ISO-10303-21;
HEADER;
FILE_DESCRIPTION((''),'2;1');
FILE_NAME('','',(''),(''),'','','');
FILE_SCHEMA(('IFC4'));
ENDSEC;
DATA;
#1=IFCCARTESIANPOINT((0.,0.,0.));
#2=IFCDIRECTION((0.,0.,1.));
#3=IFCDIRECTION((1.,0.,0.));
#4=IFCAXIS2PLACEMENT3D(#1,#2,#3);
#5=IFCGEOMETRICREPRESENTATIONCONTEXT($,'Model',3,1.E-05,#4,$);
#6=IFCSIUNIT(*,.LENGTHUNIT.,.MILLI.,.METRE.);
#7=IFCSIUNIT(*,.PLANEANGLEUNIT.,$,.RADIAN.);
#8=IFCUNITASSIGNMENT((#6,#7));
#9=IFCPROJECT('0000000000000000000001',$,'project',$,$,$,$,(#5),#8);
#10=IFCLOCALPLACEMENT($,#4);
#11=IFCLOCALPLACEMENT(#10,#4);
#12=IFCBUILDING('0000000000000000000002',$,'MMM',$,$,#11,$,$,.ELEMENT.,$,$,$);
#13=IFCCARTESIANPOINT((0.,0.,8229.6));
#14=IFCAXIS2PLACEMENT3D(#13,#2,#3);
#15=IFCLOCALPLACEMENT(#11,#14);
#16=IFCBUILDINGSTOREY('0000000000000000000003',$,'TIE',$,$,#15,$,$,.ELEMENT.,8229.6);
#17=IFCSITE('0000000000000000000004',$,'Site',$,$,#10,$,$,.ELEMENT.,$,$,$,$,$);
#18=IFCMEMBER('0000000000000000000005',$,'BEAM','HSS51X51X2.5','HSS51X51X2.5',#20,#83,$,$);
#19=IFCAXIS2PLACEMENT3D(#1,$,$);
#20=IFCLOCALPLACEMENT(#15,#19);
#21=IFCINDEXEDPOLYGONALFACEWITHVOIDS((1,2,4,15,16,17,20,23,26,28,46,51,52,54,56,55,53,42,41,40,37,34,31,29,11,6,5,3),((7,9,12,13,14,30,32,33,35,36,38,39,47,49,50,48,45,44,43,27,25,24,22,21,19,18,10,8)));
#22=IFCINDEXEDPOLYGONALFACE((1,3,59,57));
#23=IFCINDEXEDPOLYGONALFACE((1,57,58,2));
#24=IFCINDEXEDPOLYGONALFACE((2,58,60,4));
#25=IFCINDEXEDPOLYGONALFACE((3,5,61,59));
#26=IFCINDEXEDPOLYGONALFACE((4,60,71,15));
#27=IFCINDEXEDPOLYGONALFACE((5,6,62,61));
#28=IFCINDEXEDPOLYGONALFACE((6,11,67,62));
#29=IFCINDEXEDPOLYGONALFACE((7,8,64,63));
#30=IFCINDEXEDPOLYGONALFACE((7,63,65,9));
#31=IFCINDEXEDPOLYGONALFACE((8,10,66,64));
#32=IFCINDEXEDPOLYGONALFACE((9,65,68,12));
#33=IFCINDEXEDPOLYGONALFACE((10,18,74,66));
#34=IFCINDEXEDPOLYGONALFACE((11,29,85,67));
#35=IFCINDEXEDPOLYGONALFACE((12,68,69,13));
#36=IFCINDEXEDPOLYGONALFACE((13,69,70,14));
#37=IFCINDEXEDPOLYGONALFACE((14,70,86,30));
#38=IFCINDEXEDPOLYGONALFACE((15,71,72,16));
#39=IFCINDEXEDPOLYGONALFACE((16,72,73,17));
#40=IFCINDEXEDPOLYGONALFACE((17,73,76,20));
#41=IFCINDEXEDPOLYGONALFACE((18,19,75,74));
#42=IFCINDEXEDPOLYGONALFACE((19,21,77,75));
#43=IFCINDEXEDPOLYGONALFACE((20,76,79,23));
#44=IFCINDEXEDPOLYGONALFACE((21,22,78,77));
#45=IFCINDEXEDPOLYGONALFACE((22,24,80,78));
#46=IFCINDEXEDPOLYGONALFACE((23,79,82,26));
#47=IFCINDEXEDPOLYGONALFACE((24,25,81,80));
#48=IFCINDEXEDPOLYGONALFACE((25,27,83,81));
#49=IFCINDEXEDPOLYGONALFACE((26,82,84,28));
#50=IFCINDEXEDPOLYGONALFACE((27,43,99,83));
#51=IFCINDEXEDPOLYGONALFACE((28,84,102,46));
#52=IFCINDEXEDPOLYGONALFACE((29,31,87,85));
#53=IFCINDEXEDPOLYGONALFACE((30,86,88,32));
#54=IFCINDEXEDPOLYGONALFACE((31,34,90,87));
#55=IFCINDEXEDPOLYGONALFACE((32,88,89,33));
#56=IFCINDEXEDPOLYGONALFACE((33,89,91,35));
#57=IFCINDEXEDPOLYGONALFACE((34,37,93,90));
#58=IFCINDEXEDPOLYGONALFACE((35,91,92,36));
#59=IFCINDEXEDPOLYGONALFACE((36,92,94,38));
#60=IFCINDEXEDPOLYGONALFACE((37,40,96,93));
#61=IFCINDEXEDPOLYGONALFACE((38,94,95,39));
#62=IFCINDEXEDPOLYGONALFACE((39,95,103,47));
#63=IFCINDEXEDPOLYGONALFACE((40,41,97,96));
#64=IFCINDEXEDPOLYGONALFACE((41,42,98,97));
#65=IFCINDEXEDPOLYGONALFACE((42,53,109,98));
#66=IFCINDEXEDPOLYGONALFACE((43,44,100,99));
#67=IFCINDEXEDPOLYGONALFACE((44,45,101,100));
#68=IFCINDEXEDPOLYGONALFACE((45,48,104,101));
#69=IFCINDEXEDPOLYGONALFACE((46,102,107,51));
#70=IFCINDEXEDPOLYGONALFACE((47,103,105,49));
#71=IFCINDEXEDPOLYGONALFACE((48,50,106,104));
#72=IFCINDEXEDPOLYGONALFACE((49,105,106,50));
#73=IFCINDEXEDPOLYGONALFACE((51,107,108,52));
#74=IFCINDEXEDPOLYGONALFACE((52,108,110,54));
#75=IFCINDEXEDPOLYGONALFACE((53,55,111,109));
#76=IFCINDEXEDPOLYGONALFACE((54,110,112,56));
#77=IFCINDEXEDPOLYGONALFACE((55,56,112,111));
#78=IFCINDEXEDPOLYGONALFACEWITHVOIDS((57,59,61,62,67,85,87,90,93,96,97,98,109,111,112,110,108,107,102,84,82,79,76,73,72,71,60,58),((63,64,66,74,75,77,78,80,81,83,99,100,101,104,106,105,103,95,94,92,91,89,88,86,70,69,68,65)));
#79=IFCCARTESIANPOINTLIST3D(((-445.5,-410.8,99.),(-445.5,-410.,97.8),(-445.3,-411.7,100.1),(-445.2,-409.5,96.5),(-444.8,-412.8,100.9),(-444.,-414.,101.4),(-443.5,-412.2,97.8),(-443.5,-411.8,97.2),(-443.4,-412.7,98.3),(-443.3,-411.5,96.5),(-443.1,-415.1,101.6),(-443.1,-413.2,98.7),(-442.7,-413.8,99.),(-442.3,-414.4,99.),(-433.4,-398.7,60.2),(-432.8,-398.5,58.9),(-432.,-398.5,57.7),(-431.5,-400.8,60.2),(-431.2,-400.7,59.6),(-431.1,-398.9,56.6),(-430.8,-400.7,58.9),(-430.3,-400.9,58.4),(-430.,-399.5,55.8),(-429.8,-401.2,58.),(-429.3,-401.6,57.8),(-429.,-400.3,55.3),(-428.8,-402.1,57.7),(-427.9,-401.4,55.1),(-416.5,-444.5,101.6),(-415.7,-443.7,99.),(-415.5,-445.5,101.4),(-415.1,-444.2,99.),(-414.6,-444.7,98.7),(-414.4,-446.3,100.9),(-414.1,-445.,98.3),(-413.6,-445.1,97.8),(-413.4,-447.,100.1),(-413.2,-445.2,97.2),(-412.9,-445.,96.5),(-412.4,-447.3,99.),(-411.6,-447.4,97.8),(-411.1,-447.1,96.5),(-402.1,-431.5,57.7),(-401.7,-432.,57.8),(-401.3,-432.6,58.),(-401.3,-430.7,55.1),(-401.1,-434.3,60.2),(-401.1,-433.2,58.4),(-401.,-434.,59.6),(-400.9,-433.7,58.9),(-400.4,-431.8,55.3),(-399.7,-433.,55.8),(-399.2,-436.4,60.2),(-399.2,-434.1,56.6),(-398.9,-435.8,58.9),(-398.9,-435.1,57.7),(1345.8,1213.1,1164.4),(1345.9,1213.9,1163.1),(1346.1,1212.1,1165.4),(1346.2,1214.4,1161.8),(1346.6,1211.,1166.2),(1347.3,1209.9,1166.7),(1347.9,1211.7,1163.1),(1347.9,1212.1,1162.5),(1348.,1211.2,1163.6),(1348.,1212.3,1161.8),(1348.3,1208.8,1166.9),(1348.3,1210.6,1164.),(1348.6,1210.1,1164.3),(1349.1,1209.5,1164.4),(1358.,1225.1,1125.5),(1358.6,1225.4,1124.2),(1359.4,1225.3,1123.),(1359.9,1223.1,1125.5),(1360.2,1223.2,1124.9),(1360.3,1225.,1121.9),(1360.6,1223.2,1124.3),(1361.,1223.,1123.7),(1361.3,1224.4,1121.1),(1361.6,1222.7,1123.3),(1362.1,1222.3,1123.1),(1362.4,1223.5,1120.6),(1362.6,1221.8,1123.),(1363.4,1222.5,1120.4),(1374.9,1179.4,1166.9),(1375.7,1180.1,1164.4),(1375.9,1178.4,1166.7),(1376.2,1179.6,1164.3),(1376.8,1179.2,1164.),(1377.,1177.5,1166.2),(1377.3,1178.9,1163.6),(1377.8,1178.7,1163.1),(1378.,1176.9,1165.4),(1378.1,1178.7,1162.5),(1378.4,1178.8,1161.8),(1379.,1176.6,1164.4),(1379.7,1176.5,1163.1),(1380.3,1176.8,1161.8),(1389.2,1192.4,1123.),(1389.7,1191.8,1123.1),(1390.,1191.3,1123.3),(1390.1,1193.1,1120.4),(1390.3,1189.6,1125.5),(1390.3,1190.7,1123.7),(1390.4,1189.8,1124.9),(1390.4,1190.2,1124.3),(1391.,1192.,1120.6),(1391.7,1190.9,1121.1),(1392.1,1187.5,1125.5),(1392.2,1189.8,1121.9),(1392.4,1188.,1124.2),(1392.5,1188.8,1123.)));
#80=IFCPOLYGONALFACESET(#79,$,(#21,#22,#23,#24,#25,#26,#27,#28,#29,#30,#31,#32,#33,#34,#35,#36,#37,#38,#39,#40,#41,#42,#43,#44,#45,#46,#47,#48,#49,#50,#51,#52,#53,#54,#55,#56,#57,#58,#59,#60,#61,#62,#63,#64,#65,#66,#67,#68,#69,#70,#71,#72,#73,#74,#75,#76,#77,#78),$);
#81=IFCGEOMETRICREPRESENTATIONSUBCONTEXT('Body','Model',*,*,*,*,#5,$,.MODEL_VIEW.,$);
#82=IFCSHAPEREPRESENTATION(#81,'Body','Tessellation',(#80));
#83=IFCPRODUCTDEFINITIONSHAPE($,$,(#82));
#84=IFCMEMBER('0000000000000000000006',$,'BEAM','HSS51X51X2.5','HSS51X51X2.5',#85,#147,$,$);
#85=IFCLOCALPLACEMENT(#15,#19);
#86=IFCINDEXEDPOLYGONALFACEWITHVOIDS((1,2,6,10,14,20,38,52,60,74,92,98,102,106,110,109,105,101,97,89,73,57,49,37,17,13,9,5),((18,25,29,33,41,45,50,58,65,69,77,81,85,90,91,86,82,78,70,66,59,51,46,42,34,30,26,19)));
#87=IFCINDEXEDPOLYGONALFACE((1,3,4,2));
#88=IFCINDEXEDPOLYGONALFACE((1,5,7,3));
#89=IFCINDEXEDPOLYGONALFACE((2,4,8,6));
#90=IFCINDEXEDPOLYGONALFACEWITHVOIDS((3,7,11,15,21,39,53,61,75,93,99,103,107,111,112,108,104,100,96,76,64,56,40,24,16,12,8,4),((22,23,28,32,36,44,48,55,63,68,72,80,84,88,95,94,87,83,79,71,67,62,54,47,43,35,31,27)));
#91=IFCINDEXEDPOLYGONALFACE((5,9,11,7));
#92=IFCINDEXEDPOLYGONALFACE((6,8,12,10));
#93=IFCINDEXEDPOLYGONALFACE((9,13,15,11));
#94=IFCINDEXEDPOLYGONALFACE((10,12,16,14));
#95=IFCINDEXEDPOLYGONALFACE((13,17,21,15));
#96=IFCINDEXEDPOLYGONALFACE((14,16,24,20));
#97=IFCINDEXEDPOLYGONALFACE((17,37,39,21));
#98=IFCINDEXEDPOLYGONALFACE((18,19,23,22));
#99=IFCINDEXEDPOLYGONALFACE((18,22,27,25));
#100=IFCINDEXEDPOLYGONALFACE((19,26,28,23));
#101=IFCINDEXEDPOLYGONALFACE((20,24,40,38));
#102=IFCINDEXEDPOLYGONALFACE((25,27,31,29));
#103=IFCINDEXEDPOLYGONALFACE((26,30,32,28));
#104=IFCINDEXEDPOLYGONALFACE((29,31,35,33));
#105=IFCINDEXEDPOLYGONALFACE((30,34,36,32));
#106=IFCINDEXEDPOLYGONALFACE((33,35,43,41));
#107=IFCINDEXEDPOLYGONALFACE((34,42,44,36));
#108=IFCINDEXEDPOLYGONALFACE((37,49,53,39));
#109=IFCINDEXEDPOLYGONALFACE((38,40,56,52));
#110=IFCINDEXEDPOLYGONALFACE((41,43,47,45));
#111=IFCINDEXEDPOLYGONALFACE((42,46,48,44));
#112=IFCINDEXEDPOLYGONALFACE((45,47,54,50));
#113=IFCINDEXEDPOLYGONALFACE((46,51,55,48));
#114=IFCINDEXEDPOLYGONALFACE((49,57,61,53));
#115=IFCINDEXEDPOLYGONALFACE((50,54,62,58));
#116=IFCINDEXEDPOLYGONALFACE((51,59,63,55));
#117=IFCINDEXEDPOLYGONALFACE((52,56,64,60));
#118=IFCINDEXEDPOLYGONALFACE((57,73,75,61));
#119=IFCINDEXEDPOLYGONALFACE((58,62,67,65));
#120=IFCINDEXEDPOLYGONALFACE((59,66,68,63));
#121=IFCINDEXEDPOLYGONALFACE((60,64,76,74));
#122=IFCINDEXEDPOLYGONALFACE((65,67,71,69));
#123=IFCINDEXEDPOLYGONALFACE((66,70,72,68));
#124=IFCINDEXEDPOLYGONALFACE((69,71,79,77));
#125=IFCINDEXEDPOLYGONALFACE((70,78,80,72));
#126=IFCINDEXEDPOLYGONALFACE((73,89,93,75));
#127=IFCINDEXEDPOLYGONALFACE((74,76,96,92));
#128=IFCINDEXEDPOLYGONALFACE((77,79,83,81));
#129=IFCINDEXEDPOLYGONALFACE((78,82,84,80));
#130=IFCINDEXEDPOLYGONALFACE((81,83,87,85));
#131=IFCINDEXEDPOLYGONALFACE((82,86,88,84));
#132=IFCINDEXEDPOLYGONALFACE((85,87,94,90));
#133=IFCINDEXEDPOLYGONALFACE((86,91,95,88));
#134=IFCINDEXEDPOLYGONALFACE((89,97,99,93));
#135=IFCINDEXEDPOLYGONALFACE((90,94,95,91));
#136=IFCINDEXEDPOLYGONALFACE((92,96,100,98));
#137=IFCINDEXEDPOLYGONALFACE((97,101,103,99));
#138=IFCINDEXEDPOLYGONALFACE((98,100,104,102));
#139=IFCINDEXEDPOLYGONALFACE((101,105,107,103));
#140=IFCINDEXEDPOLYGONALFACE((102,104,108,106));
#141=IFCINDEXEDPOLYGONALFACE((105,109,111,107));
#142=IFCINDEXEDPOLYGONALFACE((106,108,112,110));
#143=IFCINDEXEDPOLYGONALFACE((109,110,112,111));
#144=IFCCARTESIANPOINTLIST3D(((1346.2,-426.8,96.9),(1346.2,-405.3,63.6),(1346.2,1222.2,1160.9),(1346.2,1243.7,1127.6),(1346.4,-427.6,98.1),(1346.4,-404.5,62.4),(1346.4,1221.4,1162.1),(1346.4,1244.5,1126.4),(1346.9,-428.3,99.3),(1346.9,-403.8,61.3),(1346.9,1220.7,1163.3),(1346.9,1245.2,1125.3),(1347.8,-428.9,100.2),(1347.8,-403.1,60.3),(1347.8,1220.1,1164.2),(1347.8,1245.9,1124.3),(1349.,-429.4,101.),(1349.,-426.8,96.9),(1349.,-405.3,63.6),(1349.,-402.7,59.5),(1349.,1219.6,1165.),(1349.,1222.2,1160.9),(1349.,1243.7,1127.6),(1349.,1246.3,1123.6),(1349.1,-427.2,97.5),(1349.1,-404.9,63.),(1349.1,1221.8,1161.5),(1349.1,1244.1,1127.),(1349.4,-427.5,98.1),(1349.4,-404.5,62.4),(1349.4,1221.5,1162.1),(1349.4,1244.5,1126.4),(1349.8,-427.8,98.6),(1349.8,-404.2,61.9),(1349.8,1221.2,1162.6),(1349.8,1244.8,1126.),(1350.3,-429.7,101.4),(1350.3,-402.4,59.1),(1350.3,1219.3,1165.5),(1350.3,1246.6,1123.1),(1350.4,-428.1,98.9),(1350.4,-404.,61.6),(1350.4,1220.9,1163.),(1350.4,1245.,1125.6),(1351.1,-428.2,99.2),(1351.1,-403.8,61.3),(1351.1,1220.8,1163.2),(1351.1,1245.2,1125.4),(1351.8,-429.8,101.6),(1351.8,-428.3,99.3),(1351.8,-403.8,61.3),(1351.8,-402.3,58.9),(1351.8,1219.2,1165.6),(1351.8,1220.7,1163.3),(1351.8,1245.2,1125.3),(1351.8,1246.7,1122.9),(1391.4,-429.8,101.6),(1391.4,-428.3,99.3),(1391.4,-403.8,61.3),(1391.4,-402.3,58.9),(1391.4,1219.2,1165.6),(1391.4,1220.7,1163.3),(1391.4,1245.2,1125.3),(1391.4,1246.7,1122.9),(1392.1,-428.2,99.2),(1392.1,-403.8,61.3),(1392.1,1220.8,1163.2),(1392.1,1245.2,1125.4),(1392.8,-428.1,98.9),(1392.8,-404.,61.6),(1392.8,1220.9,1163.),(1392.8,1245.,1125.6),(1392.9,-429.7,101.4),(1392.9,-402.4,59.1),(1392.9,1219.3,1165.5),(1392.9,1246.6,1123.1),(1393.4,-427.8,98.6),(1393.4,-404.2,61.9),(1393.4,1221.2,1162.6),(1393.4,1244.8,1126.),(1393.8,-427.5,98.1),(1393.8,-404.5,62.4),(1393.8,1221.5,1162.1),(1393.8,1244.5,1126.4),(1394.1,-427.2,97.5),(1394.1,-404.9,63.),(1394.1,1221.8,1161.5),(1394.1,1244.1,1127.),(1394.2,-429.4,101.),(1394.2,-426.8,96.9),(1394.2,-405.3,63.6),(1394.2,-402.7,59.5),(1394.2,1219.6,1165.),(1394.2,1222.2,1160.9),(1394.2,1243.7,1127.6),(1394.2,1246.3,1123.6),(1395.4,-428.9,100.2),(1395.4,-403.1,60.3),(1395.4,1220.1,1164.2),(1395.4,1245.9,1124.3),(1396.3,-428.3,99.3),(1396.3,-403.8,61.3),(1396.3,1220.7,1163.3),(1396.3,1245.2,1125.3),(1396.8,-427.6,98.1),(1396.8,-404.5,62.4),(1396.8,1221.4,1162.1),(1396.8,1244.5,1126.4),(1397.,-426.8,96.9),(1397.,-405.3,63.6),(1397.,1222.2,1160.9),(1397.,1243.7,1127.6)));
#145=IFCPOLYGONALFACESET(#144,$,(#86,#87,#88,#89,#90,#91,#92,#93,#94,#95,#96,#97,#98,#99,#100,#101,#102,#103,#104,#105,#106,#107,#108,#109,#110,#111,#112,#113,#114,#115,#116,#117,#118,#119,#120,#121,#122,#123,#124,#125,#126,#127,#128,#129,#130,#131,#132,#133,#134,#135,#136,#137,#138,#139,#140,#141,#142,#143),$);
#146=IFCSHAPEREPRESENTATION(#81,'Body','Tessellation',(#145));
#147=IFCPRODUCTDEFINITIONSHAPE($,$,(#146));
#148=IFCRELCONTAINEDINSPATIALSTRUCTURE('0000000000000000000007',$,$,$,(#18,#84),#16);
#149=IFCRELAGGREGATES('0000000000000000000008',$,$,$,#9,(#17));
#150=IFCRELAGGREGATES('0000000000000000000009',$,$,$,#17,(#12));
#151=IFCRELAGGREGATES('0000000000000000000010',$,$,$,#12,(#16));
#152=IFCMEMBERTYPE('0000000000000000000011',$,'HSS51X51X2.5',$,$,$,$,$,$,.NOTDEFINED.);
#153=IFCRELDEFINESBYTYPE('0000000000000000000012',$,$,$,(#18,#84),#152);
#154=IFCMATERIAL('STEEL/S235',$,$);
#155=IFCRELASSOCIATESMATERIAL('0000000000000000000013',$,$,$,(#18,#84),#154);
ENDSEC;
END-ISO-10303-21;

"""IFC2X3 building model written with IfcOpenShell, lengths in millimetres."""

from ifc_helpers import new_model, si_unit, frame, origin_with_axes, origin_2d_with_axis, place, context, subcontext, project, spatial, hollow_rectangle, extrude, material, type_object, element, save


model = new_model("IFC2X3")

# Units and contexts
model_context = context("Model", 3, precision=1e-05, world=origin_with_axes())
body_context = subcontext(model_context, "Body", "Model", "MODEL_VIEW")
ifc_project = project(units=[si_unit("LENGTHUNIT", "METRE", prefix="MILLI"), si_unit("PLANEANGLEUNIT", "RADIAN")], contexts=[model_context])

# Site, building, storey
site_placement = place(None, origin_with_axes())
site = spatial("IfcSite", under=ifc_project, at=site_placement, Name="Site", CompositionType="ELEMENT")
building_placement = place(site_placement, origin_with_axes())
building = spatial("IfcBuilding", under=site, at=building_placement, Name="MMM", CompositionType="ELEMENT")
storey_placement = place(building_placement, frame((0.0, 0.0, 8229.6), z_axis=(0.0, 0.0, 1.0), x_axis=(1.0, 0.0, 0.0)))
storey = spatial("IfcBuildingStorey", under=building, at=storey_placement, Name="TIE", CompositionType="ELEMENT", Elevation=8229.6)

# Shared definitions
ifc_material = material(Name="STEEL/S235")

# Members
member_type_1 = type_object("IfcMemberType", Name="HSS51X51X2.5", PredefinedType="NOTDEFINED")
member_1_placement = place(storey_placement, frame((1369.2, 1200.9, 1143.7), z_axis=(-0.298731, -0.270799, 0.915111), x_axis=(-0.678002, -0.614607, -0.403203)))
element("IfcMember", 1, at=member_1_placement, inside=storey, type_object=member_type_1, material=ifc_material, Name="BEAM", Description="HSS51X51X2.5", ObjectType="HSS51X51X2.5", context=body_context, shape_type="SweptSolid", body=[
    extrude(hollow_rectangle(XDim=50.8, YDim=50.8, WallThickness=2.8, InnerFilletRadius=2.8, OuterFilletRadius=5.6, at=origin_2d_with_axis()), frame((2642.1, 0.0, 0.0), z_axis=(-1.0, 0.0, 0.0), x_axis=(0.0, -1.0, 0.0)), (0.0, 0.0, 1.0), 2642.1),
])
member_2_placement = place(storey_placement, frame((1371.6, 1233.0, 1144.3), z_axis=(0.0, -0.542177, 0.840264), x_axis=(0.0, -0.840264, -0.542177)))
element("IfcMember", 2, at=member_2_placement, inside=storey, type_object=member_type_1, material=ifc_material, Name="BEAM", Description="HSS51X51X2.5", ObjectType="HSS51X51X2.5", context=body_context, shape_type="SweptSolid", body=[
    extrude(hollow_rectangle(XDim=50.8, YDim=50.8, WallThickness=2.8, InnerFilletRadius=2.8, OuterFilletRadius=5.6, at=origin_2d_with_axis()), frame((1962.5, 0.0, 0.0), z_axis=(-1.0, 0.0, 0.0), x_axis=(0.0, -1.0, 0.0)), (0.0, 0.0, 1.0), 1962.5),
])

save(model, "model.ifc")
